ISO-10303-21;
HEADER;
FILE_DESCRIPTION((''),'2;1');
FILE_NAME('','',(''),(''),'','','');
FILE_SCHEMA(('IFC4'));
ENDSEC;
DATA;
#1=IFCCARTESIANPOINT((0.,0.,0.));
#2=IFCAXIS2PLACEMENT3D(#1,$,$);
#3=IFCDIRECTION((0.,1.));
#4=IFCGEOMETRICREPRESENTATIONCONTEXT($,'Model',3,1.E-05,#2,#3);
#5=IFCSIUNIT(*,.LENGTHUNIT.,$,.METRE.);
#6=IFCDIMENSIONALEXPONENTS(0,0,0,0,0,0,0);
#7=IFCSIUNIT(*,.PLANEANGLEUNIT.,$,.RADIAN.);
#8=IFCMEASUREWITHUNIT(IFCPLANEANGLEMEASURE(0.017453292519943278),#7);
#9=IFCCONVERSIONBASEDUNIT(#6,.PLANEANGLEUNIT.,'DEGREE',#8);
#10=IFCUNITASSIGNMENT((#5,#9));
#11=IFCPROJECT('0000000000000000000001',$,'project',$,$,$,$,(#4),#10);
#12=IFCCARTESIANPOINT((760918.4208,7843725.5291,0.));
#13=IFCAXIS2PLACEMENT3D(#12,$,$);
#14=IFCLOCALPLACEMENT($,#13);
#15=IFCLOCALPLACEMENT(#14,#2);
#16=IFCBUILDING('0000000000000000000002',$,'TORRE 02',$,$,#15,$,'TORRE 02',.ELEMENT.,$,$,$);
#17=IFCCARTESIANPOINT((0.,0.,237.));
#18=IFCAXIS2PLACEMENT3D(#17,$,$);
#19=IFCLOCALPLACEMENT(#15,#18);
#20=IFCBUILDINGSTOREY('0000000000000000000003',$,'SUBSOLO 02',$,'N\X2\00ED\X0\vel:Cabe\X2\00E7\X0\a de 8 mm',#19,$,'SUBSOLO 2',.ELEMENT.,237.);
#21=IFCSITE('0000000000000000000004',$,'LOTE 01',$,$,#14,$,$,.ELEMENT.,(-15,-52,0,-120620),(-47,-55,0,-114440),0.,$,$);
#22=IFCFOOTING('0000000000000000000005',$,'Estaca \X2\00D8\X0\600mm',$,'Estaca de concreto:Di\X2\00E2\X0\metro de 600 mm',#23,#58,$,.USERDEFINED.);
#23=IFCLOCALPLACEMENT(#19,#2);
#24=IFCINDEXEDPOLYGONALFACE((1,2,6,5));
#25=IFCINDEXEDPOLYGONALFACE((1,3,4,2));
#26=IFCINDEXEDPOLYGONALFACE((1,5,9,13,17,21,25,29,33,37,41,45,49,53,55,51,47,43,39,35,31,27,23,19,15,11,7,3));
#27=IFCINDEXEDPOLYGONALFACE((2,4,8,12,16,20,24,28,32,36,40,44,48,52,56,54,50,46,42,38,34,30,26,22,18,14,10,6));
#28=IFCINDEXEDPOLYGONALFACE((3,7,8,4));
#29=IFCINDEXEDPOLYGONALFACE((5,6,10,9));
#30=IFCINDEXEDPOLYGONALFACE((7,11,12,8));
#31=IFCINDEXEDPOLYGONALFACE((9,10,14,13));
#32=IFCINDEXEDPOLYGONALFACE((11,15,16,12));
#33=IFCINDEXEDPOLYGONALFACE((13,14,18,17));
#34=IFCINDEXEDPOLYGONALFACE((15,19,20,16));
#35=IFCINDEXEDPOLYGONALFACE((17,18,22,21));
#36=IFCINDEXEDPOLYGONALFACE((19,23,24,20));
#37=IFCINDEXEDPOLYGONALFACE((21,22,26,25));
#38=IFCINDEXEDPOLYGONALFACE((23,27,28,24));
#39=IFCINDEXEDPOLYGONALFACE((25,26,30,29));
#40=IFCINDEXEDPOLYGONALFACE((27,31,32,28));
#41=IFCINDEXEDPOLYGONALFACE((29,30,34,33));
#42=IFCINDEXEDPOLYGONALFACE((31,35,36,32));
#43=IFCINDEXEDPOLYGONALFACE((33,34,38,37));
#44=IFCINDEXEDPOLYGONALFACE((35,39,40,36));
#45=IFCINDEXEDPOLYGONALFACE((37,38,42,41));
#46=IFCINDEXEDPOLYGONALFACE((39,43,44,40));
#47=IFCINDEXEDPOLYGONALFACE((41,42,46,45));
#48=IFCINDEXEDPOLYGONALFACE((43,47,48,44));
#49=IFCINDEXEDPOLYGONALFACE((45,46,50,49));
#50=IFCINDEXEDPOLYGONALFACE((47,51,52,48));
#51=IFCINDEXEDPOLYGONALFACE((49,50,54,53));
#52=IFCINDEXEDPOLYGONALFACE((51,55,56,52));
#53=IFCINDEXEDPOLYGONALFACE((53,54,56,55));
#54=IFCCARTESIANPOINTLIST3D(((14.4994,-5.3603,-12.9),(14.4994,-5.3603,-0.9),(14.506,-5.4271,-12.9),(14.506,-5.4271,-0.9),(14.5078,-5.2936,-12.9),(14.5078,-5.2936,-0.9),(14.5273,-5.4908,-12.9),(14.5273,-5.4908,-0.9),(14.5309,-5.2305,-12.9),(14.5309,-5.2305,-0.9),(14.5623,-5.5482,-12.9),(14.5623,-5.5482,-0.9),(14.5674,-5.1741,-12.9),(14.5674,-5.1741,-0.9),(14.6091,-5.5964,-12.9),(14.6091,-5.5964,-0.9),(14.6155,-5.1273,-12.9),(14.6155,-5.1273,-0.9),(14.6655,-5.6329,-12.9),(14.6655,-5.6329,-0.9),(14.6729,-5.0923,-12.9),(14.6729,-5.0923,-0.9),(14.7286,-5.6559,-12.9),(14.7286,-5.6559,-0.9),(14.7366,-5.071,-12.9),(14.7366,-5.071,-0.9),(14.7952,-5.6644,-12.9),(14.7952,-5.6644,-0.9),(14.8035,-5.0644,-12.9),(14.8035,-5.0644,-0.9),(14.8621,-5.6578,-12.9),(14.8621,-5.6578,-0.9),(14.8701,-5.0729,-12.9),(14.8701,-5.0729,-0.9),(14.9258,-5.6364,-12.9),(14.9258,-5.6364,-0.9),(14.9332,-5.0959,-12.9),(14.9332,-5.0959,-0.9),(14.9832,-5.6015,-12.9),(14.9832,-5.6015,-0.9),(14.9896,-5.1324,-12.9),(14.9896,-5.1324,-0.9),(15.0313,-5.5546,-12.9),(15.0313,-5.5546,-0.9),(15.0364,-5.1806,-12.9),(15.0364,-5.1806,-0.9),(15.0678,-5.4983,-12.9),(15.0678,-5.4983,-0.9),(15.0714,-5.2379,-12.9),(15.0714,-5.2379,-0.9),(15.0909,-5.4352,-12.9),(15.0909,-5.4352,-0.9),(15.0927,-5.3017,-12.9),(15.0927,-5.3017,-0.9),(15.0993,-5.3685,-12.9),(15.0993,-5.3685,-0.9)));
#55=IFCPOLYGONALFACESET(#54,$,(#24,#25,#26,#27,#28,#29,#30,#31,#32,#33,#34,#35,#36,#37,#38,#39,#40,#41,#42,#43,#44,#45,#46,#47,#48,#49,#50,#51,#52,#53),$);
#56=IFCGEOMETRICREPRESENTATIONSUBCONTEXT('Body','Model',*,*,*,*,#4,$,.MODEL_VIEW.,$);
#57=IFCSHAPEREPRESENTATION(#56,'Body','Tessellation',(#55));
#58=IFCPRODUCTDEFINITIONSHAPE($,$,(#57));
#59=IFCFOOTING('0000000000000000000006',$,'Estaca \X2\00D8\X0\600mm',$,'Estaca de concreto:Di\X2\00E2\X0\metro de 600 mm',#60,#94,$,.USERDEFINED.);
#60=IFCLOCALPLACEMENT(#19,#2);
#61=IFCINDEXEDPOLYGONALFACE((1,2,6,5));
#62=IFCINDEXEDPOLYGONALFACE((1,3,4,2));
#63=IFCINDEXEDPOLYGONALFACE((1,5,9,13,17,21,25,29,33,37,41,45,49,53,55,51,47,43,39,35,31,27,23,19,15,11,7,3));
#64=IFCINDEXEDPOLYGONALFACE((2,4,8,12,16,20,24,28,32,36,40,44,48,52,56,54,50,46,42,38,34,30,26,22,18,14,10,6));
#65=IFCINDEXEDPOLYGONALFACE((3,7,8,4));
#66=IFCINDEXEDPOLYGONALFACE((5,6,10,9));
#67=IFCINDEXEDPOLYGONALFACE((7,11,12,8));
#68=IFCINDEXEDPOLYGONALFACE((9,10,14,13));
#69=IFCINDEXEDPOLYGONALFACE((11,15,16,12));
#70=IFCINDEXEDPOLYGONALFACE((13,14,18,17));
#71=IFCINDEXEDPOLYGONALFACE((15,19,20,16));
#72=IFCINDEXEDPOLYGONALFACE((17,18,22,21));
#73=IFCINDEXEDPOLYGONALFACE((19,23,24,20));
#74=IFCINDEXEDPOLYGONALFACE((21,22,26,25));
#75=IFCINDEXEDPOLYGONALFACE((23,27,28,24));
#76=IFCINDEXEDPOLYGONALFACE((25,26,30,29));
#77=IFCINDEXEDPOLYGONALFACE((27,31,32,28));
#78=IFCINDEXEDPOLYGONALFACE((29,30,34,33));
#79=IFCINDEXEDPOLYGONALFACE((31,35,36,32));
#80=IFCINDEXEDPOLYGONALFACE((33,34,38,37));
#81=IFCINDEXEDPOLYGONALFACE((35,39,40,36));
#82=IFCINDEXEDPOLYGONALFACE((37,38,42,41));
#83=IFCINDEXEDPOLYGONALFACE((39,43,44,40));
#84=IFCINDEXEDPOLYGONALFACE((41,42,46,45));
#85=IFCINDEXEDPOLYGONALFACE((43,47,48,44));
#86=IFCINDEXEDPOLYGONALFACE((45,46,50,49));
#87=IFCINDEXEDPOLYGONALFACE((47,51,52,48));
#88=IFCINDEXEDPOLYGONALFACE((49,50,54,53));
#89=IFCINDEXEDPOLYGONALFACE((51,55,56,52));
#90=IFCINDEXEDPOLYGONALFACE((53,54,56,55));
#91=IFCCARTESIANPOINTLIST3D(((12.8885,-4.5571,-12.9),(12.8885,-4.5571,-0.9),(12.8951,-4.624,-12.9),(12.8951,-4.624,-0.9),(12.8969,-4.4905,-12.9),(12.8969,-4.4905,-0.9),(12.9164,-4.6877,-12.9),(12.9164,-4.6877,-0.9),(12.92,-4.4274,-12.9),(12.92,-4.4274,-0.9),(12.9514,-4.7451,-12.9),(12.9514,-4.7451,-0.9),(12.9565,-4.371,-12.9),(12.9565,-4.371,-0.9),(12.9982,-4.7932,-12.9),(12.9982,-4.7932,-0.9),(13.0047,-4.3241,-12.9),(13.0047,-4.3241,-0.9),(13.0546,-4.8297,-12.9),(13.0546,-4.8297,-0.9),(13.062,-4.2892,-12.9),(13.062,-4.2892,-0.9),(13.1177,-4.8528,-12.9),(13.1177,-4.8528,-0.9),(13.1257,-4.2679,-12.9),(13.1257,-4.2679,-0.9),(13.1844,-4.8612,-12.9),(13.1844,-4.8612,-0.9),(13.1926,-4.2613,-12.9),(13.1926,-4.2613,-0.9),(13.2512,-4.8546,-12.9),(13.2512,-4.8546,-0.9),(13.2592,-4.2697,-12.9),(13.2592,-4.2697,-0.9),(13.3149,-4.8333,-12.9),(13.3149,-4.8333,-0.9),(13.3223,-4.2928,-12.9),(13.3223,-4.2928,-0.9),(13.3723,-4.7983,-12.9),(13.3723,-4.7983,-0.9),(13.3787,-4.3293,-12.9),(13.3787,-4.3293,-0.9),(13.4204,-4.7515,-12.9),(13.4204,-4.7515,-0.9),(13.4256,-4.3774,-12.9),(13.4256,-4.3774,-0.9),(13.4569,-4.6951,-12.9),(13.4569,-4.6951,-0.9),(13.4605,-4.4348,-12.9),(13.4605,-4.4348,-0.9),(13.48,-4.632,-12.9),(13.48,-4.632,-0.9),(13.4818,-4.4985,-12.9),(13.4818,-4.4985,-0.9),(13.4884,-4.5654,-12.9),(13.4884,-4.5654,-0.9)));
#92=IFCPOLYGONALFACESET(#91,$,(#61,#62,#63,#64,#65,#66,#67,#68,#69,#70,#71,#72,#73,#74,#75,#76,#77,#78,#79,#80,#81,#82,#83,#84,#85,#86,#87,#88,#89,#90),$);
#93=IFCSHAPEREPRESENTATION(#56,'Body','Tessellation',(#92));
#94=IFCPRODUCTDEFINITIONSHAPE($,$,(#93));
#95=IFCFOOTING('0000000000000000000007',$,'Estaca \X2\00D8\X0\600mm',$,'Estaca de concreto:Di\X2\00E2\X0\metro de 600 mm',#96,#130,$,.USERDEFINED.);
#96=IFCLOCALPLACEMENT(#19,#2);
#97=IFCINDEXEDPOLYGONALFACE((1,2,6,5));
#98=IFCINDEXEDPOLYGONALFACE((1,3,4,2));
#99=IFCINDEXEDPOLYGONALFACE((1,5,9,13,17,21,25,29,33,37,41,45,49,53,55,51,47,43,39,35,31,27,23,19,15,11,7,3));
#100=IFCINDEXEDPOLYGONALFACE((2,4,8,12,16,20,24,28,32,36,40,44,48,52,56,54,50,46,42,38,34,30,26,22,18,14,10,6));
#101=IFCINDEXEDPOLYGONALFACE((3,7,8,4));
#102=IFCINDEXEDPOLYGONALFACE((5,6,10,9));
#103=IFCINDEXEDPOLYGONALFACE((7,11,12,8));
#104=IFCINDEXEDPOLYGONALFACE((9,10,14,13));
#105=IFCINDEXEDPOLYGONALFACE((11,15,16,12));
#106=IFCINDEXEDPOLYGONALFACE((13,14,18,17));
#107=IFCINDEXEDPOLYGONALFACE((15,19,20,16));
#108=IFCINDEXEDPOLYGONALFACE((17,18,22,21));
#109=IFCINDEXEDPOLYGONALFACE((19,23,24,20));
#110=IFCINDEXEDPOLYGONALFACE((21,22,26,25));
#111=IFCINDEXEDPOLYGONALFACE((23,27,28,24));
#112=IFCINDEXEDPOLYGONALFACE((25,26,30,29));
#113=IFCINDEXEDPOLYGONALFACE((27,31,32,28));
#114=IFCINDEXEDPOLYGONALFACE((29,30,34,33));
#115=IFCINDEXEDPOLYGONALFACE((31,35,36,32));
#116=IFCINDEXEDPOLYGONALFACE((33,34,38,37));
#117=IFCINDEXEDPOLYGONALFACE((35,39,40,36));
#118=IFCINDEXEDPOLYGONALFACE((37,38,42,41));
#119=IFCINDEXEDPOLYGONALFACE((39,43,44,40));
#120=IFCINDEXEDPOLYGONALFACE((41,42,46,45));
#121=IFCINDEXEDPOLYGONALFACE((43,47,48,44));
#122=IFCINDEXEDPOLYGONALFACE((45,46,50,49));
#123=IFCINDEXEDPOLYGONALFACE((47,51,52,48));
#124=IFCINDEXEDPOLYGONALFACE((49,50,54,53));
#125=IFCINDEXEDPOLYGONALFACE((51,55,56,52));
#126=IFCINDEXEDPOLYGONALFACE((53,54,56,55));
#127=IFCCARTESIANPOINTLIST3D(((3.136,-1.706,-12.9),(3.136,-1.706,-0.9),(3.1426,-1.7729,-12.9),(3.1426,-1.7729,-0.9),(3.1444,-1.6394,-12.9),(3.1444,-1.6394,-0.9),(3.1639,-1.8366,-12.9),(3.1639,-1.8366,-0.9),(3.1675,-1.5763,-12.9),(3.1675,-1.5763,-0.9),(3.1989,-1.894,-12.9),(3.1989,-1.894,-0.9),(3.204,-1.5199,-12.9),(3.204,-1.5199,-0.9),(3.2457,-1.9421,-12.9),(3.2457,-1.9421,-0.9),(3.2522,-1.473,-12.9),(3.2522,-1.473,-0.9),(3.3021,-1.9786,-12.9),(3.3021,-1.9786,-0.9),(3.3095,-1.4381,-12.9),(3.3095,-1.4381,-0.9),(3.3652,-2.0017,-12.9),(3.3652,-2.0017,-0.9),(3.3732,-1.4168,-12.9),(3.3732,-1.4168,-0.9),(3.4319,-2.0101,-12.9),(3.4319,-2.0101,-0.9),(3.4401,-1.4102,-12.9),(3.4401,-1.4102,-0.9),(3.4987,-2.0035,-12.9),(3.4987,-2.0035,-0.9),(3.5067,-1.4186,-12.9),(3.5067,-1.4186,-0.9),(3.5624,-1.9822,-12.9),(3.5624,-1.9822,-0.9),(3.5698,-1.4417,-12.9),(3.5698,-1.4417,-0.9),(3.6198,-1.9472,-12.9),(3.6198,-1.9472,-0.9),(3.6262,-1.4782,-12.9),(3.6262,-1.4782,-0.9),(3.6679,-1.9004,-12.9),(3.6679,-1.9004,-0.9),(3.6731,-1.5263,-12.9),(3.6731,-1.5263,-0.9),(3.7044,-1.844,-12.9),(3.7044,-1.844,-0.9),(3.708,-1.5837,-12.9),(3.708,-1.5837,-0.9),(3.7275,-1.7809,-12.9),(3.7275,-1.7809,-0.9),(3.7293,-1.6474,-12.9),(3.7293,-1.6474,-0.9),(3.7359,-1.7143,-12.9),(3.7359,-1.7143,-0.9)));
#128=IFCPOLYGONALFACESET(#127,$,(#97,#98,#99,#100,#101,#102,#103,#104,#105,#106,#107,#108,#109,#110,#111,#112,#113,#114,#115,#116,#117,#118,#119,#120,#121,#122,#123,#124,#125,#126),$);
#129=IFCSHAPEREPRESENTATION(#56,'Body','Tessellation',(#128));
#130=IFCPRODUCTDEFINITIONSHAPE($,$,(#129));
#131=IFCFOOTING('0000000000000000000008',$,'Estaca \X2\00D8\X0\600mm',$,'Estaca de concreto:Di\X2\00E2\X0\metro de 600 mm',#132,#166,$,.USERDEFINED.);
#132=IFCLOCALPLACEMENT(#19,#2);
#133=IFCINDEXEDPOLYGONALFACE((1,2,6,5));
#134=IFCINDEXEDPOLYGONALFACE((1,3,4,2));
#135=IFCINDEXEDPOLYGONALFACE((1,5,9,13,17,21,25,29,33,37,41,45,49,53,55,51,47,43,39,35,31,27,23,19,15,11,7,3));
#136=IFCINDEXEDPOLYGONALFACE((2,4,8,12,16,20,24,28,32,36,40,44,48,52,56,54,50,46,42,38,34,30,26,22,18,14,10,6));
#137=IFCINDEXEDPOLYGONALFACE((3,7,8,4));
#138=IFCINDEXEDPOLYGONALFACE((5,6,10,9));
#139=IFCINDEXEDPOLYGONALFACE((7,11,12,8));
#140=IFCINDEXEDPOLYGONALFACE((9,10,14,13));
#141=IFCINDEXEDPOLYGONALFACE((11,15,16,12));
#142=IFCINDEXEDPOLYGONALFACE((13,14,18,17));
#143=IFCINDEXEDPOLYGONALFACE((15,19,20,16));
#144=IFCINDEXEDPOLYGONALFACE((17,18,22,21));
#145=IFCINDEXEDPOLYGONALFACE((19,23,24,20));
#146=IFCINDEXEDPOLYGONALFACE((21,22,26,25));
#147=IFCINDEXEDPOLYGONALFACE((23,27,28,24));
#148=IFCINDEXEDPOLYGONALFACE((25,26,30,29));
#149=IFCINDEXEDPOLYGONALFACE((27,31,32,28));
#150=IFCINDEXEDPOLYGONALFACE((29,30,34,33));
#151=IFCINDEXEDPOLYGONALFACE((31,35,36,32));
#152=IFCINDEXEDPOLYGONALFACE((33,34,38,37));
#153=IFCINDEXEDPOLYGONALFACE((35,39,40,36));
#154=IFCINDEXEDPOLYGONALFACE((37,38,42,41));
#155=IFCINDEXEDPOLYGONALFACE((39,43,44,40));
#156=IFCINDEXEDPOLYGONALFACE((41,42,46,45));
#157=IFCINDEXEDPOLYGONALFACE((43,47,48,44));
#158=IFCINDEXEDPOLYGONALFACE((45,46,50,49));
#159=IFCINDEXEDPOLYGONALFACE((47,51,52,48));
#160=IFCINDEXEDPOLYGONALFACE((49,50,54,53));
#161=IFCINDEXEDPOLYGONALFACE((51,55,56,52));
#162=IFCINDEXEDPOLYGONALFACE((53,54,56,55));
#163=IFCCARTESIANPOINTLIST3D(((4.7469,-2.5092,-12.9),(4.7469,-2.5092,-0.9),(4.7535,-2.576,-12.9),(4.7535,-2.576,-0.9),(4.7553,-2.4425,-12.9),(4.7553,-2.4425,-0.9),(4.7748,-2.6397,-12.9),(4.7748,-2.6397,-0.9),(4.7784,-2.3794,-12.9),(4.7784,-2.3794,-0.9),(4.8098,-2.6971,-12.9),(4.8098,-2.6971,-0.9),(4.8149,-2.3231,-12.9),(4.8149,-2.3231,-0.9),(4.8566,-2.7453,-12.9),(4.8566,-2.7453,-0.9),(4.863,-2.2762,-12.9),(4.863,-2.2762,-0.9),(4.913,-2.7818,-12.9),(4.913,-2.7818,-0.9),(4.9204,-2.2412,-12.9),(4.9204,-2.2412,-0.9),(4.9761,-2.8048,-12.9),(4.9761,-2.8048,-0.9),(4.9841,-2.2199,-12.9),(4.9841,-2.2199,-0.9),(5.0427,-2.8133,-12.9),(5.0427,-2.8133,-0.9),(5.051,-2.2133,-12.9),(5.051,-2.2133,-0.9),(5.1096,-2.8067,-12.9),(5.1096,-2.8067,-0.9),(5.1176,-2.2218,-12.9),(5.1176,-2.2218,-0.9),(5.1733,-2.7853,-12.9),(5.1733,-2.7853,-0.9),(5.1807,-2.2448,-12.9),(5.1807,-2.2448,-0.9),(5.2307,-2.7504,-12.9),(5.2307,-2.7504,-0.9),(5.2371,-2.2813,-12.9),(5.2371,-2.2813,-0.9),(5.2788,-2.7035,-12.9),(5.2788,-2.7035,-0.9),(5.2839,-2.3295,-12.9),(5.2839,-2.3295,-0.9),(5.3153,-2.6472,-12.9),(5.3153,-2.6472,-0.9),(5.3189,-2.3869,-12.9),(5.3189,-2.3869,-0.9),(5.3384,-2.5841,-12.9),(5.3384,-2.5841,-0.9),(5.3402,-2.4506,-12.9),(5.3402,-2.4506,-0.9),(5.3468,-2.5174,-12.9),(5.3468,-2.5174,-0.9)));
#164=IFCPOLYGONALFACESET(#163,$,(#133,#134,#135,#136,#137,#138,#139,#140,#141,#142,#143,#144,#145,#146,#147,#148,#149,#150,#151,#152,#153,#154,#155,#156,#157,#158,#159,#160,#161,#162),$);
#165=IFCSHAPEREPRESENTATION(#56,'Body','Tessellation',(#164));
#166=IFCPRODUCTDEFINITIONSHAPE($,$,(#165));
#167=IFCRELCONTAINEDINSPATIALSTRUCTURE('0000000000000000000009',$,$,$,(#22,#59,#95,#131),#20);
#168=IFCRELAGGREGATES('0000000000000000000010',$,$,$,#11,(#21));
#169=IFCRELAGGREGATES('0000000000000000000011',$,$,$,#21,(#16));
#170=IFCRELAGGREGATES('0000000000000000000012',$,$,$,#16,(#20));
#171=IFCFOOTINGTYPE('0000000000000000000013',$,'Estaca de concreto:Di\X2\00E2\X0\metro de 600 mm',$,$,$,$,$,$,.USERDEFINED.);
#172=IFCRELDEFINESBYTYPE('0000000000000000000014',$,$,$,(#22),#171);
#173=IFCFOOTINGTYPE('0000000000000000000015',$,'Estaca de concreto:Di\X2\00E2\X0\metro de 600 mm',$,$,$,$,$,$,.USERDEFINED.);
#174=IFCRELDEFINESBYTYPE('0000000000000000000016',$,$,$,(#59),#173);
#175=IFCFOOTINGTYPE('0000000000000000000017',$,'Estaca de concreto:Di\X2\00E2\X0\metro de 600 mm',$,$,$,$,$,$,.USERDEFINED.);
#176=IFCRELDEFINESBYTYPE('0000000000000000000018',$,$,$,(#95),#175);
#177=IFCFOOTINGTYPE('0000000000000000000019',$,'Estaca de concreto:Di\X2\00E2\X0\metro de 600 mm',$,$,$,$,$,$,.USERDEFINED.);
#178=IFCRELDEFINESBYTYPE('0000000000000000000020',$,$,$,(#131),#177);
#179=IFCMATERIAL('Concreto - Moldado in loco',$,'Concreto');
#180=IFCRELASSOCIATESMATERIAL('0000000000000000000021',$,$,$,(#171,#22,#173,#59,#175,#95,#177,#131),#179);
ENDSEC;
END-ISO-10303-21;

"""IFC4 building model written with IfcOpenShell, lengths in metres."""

from ifc_helpers import new_model, entity, si_unit, converted_unit, direction, frame, origin, place, context, subcontext, project, spatial, arc, indexed_curve, outline, extrude, source, transform, mapped, material, type_object, type_shapes, element, save


model = new_model("IFC4")

# Units and contexts
model_context = context("Model", 3, precision=1e-05, world=origin(), true_north=direction((0.0, 1.0)))
body_context = subcontext(model_context, "Body", "Model", "MODEL_VIEW")
ifc_project = project(units=[si_unit("LENGTHUNIT", "METRE"), converted_unit("PLANEANGLEUNIT", "DEGREE", entity("IfcPlaneAngleMeasure", 0.017453292519943278), si_unit("PLANEANGLEUNIT", "RADIAN"), dimensions=[0, 0, 0, 0, 0, 0, 0])], contexts=[model_context])

# Site, building, storey
site_placement = place(None, frame((760918.4208, 7843725.5291, 0.0)))
site = spatial("IfcSite", under=ifc_project, at=site_placement, Name="LOTE 01", CompositionType="ELEMENT", RefLatitude=(-15, -52, 0, -120620), RefLongitude=(-47, -55, 0, -114440), RefElevation=0.0)
building_placement = place(site_placement, origin())
building = spatial("IfcBuilding", under=site, at=building_placement, Name="TORRE 02", LongName="TORRE 02", CompositionType="ELEMENT")
storey_placement = place(building_placement, frame((0.0, 0.0, 237.0)))
storey = spatial("IfcBuildingStorey", under=building, at=storey_placement, Name="SUBSOLO 02", ObjectType="Nível:Cabeça de 8 mm", LongName="SUBSOLO 2", CompositionType="ELEMENT", Elevation=237.0)

# Footings
ifc_material = material(Name="Concreto - Moldado in loco", Category="Concreto")
placement = place(building_placement, frame((0.0, 0.0, 237.0)))
footing_type_1 = type_object("IfcFootingType", Name="Estaca de concreto:Diâmetro de 600 mm", PredefinedType="USERDEFINED", material=ifc_material)
shared_shape_1 = source(origin(), body_context, "Body", "SweptSolid", [
    extrude(outline(indexed_curve([(-0.3, 0.0), (0.0, -0.3), (0.3, 0.0), (0.0, 0.3)], segments=[arc(1, 2, 3), arc(3, 4, 1)], self_intersect=False)), frame((14.7993, -5.3644, -12.0), z_axis=(0.0, 0.0, 1.0), x_axis=(0.894934, -0.446198, 0.0)), (0.0, 0.0, 1.0), 12.0),
])
type_shapes(footing_type_1, [shared_shape_1])
footing_1_placement = place(placement, frame((0.0, 0.0, -0.9)))
element("IfcFooting", 1, at=footing_1_placement, inside=storey, type_object=footing_type_1, material=ifc_material, Name="Estaca Ø600mm", ObjectType="Estaca de concreto:Diâmetro de 600 mm", PredefinedType="USERDEFINED", context=body_context, shape_type="MappedRepresentation", body=[
    mapped(shared_shape_1, transform((0.0, 0.0, 0.0), scale=1.0)),
])
footing_type_2 = type_object("IfcFootingType", Name="Estaca de concreto:Diâmetro de 600 mm", PredefinedType="USERDEFINED", material=ifc_material)
shared_shape_2 = source(origin(), body_context, "Body", "SweptSolid", [
    extrude(outline(indexed_curve([(-0.3, 0.0), (0.0, -0.3), (0.3, 0.0), (0.0, 0.3)], segments=[arc(1, 2, 3), arc(3, 4, 1)], self_intersect=False)), frame((13.1885, -4.5612, -12.0), z_axis=(0.0, 0.0, 1.0), x_axis=(0.894934, -0.446198, 0.0)), (0.0, 0.0, 1.0), 12.0),
])
type_shapes(footing_type_2, [shared_shape_2])
footing_2_placement = place(placement, frame((0.0, 0.0, -0.9)))
element("IfcFooting", 2, at=footing_2_placement, inside=storey, type_object=footing_type_2, material=ifc_material, Name="Estaca Ø600mm", ObjectType="Estaca de concreto:Diâmetro de 600 mm", PredefinedType="USERDEFINED", context=body_context, shape_type="MappedRepresentation", body=[
    mapped(shared_shape_2, transform((0.0, 0.0, 0.0), scale=1.0)),
])
footing_type_3 = type_object("IfcFootingType", Name="Estaca de concreto:Diâmetro de 600 mm", PredefinedType="USERDEFINED", material=ifc_material)
shared_shape_3 = source(origin(), body_context, "Body", "SweptSolid", [
    extrude(outline(indexed_curve([(-0.3, 0.0), (0.0, -0.3), (0.3, 0.0), (0.0, 0.3)], segments=[arc(1, 2, 3), arc(3, 4, 1)], self_intersect=False)), frame((3.436, -1.7101, -12.0), z_axis=(0.0, 0.0, 1.0), x_axis=(0.894934, -0.446198, 0.0)), (0.0, 0.0, 1.0), 12.0),
])
type_shapes(footing_type_3, [shared_shape_3])
footing_3_placement = place(placement, frame((0.0, 0.0, -0.9)))
element("IfcFooting", 3, at=footing_3_placement, inside=storey, type_object=footing_type_3, material=ifc_material, Name="Estaca Ø600mm", ObjectType="Estaca de concreto:Diâmetro de 600 mm", PredefinedType="USERDEFINED", context=body_context, shape_type="MappedRepresentation", body=[
    mapped(shared_shape_3, transform((0.0, 0.0, 0.0), scale=1.0)),
])
footing_type_4 = type_object("IfcFootingType", Name="Estaca de concreto:Diâmetro de 600 mm", PredefinedType="USERDEFINED", material=ifc_material)
shared_shape_4 = source(origin(), body_context, "Body", "SweptSolid", [
    extrude(outline(indexed_curve([(-0.3, 0.0), (0.0, -0.3), (0.3, 0.0), (0.0, 0.3)], segments=[arc(1, 2, 3), arc(3, 4, 1)], self_intersect=False)), frame((5.0468, -2.5133, -12.0), z_axis=(0.0, 0.0, 1.0), x_axis=(0.894934, -0.446198, 0.0)), (0.0, 0.0, 1.0), 12.0),
])
type_shapes(footing_type_4, [shared_shape_4])
footing_4_placement = place(placement, frame((0.0, 0.0, -0.9)))
element("IfcFooting", 4, at=footing_4_placement, inside=storey, type_object=footing_type_4, material=ifc_material, Name="Estaca Ø600mm", ObjectType="Estaca de concreto:Diâmetro de 600 mm", PredefinedType="USERDEFINED", context=body_context, shape_type="MappedRepresentation", body=[
    mapped(shared_shape_4, transform((0.0, 0.0, 0.0), scale=1.0)),
])

save(model, "model.ifc")
